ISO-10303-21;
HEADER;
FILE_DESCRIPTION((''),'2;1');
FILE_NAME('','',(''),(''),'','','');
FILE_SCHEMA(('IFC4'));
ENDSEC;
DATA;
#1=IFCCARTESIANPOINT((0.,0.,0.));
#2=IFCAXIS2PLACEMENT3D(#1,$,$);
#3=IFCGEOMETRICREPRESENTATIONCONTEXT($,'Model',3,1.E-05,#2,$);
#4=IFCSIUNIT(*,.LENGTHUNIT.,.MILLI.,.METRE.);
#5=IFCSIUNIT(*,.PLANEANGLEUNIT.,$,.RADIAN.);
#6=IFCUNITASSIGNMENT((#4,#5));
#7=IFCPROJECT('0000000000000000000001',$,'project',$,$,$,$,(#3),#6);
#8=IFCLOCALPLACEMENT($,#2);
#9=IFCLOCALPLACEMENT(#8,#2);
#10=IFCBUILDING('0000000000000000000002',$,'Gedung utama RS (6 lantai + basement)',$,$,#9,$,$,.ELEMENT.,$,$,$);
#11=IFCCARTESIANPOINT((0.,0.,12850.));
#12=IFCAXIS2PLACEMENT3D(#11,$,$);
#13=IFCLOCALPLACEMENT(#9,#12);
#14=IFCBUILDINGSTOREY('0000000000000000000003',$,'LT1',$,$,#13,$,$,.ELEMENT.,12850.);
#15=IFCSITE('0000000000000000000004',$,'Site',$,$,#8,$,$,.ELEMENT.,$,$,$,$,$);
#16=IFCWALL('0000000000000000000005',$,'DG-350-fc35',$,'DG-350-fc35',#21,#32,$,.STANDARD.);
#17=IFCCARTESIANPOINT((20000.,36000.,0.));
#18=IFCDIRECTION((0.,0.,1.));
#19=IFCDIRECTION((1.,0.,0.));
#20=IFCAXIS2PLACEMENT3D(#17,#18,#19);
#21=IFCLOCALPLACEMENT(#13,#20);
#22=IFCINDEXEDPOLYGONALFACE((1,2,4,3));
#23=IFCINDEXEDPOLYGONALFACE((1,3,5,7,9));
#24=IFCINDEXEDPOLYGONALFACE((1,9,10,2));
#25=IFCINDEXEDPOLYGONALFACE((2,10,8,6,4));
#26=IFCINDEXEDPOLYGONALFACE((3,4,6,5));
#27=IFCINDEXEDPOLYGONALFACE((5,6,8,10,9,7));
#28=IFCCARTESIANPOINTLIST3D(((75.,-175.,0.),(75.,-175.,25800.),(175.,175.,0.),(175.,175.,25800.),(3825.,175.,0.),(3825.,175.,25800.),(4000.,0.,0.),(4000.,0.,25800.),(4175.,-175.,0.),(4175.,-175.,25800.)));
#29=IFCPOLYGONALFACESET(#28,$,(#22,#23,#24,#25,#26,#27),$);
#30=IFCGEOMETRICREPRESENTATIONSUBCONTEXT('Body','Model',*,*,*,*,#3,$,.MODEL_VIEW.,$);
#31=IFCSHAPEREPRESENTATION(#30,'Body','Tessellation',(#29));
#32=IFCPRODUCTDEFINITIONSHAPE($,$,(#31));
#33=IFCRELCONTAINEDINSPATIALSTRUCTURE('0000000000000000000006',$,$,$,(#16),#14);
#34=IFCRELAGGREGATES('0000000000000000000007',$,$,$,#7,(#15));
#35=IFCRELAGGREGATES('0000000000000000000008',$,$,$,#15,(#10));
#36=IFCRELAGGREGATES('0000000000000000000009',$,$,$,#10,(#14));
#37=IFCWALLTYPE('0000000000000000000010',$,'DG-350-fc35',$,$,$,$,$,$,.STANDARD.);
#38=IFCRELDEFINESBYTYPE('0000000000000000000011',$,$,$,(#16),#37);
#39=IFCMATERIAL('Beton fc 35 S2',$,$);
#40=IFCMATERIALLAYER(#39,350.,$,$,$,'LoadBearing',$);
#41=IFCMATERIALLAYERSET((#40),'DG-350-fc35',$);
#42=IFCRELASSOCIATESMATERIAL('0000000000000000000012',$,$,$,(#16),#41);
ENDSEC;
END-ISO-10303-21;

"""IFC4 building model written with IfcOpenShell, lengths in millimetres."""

from ifc_helpers import new_model, si_unit, frame, origin, place, context, subcontext, project, spatial, polyline, outline, extrude, material, layer, layer_set, layer_usage, type_object, element, save


model = new_model("IFC4")

# Units and contexts
model_context = context("Model", 3, precision=1e-05, world=origin())
body_context = subcontext(model_context, "Body", "Model", "MODEL_VIEW")
ifc_project = project(units=[si_unit("LENGTHUNIT", "METRE", prefix="MILLI"), si_unit("PLANEANGLEUNIT", "RADIAN")], contexts=[model_context])

# Site, building, storey
site_placement = place(None, origin())
site = spatial("IfcSite", under=ifc_project, at=site_placement, Name="Site", CompositionType="ELEMENT")
building_placement = place(site_placement, origin())
building = spatial("IfcBuilding", under=site, at=building_placement, Name="Gedung utama RS (6 lantai + basement)", CompositionType="ELEMENT")
storey_placement = place(building_placement, frame((0.0, 0.0, 12850.0)))
storey = spatial("IfcBuildingStorey", under=building, at=storey_placement, Name="LT1", CompositionType="ELEMENT", Elevation=12850.0)

# Wall
ifc_material_1 = material(Name="Beton fc 35 S2")
ifc_layer_1 = layer(ifc_material_1, 350.0, Category="LoadBearing")
ifc_layer_set_1 = layer_set([ifc_layer_1], Name="DG-350-fc35")
ifc_layer_usage_1 = layer_usage(ifc_layer_set_1, "AXIS2", "NEGATIVE", 175.0)
wall_type_1 = type_object("IfcWallType", Name="DG-350-fc35", PredefinedType="STANDARD")
wall_1_placement = place(storey_placement, frame((20000.0, 36000.0, 0.0), z_axis=(0.0, 0.0, 1.0), x_axis=(1.0, 0.0, 0.0)))
element("IfcWall", 1, at=wall_1_placement, inside=storey, type_object=wall_type_1, material=ifc_layer_usage_1, Name="DG-350-fc35", ObjectType="DG-350-fc35", PredefinedType="STANDARD", context=body_context, shape_type="SweptSolid", body=[
    extrude(outline(polyline([(75.0, -175.0), (175.0, 175.0), (3825.0, 175.0), (4000.0, 0.0), (4175.0, -175.0), (75.0, -175.0)])), origin(), (0.0, 0.0, 1.0), 25800.0),
])

save(model, "model.ifc")
